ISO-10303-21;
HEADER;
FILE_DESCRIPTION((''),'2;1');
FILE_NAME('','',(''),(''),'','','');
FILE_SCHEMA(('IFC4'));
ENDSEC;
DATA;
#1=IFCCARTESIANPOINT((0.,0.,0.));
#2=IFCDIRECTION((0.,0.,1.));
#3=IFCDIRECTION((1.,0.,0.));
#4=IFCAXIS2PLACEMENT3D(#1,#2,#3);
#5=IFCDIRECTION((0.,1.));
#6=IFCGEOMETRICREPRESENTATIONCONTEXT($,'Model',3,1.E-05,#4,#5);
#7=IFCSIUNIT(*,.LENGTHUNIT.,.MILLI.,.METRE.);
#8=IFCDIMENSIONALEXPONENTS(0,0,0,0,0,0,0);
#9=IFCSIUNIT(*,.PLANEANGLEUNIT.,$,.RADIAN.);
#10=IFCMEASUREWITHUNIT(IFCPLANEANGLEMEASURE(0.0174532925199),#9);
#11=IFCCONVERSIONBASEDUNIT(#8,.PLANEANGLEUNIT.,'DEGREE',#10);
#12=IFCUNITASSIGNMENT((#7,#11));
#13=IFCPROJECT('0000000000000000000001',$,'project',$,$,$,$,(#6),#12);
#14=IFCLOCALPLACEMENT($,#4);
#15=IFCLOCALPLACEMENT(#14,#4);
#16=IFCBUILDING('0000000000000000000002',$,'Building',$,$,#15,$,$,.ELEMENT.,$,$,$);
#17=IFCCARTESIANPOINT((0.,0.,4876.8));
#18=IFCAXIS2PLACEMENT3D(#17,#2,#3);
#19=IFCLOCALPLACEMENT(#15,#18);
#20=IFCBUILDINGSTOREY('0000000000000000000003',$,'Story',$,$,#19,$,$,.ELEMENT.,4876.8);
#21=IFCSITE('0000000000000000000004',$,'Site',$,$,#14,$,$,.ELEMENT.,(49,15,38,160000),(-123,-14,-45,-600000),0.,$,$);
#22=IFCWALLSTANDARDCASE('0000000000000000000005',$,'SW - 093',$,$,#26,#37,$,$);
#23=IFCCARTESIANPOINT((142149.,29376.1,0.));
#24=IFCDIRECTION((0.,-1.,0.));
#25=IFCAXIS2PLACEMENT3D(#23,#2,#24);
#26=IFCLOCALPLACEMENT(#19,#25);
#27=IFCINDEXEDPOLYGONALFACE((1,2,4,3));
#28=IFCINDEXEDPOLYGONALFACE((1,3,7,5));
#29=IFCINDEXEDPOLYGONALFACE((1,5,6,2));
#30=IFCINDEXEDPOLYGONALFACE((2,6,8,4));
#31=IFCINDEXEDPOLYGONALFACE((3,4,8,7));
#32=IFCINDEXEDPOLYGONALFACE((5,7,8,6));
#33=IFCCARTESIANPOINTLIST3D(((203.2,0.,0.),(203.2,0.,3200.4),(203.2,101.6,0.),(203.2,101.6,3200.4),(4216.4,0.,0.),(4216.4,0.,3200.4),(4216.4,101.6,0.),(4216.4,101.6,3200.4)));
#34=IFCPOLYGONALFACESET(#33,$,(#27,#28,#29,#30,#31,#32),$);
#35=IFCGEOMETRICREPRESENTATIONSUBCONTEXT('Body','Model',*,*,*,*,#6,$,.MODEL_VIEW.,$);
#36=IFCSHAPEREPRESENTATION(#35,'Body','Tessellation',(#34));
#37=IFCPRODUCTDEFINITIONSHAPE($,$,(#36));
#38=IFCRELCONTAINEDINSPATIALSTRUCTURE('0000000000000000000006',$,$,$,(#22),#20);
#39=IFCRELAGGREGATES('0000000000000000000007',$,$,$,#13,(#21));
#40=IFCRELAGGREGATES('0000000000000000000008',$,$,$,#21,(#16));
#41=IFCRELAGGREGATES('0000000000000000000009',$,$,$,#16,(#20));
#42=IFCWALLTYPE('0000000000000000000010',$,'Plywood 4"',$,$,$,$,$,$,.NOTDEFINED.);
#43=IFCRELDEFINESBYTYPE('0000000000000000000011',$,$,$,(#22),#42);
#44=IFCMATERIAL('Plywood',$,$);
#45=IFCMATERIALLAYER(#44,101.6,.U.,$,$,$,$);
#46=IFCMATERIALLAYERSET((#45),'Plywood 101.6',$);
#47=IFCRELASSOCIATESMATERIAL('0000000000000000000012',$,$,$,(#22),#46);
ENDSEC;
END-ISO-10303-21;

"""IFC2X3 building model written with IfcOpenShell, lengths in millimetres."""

from ifc_helpers import new_model, entity, si_unit, converted_unit, direction, frame, origin_with_axes, place, context, subcontext, project, spatial, polyline, outline, extrude, material, layer, layer_set, layer_usage, type_object, element, save


model = new_model("IFC2X3")

# Units and contexts
model_context = context("Model", 3, precision=1e-05, world=origin_with_axes(), true_north=direction((0.0, 1.0)))
body_context = subcontext(model_context, "Body", "Model", "MODEL_VIEW")
ifc_project = project(units=[si_unit("LENGTHUNIT", "METRE", prefix="MILLI"), converted_unit("PLANEANGLEUNIT", "DEGREE", entity("IfcPlaneAngleMeasure", 0.0174532925199), si_unit("PLANEANGLEUNIT", "RADIAN"), dimensions=[0, 0, 0, 0, 0, 0, 0])], contexts=[model_context])

# Site, building, storey
site_placement = place(None, origin_with_axes())
site = spatial("IfcSite", under=ifc_project, at=site_placement, Name="Site", CompositionType="ELEMENT", RefLatitude=(49, 15, 38, 160000), RefLongitude=(-123, -14, -45, -600000), RefElevation=0.0)
building_placement = place(site_placement, origin_with_axes())
building = spatial("IfcBuilding", under=site, at=building_placement, Name="Building", CompositionType="ELEMENT")
storey_placement = place(building_placement, frame((0.0, 0.0, 4876.8), z_axis=(0.0, 0.0, 1.0), x_axis=(1.0, 0.0, 0.0)))
storey = spatial("IfcBuildingStorey", under=building, at=storey_placement, Name="Story", CompositionType="ELEMENT", Elevation=4876.8)

# Shared definitions
ifc_material_1 = material(Name="Plywood")

# Wall
ifc_layer_1 = layer(ifc_material_1, 101.6, ventilated="UNKNOWN")
ifc_layer_set_1 = layer_set([ifc_layer_1], Name="Plywood 101.6")
wall_type_1 = type_object("IfcWallType", Name="Plywood 4\"", PredefinedType="NOTDEFINED")
ifc_layer_usage_1 = layer_usage(ifc_layer_set_1, "AXIS2", "POSITIVE", 0.0)
wall_1_placement = place(storey_placement, frame((142149.0, 29376.1, 0.0), z_axis=(0.0, 0.0, 1.0), x_axis=(0.0, -1.0, 0.0)))
element("IfcWallStandardCase", 1, at=wall_1_placement, inside=storey, type_object=wall_type_1, material=ifc_layer_usage_1, Name="SW - 093", context=body_context, shape_type="SweptSolid", body=[
    extrude(outline(polyline([(203.2, 0.0), (4216.4, 0.0), (4216.4, 101.6), (203.2, 101.6), (203.2, 0.0)])), origin_with_axes(), (0.0, 0.0, 1.0), 3200.4),
])

save(model, "model.ifc")
